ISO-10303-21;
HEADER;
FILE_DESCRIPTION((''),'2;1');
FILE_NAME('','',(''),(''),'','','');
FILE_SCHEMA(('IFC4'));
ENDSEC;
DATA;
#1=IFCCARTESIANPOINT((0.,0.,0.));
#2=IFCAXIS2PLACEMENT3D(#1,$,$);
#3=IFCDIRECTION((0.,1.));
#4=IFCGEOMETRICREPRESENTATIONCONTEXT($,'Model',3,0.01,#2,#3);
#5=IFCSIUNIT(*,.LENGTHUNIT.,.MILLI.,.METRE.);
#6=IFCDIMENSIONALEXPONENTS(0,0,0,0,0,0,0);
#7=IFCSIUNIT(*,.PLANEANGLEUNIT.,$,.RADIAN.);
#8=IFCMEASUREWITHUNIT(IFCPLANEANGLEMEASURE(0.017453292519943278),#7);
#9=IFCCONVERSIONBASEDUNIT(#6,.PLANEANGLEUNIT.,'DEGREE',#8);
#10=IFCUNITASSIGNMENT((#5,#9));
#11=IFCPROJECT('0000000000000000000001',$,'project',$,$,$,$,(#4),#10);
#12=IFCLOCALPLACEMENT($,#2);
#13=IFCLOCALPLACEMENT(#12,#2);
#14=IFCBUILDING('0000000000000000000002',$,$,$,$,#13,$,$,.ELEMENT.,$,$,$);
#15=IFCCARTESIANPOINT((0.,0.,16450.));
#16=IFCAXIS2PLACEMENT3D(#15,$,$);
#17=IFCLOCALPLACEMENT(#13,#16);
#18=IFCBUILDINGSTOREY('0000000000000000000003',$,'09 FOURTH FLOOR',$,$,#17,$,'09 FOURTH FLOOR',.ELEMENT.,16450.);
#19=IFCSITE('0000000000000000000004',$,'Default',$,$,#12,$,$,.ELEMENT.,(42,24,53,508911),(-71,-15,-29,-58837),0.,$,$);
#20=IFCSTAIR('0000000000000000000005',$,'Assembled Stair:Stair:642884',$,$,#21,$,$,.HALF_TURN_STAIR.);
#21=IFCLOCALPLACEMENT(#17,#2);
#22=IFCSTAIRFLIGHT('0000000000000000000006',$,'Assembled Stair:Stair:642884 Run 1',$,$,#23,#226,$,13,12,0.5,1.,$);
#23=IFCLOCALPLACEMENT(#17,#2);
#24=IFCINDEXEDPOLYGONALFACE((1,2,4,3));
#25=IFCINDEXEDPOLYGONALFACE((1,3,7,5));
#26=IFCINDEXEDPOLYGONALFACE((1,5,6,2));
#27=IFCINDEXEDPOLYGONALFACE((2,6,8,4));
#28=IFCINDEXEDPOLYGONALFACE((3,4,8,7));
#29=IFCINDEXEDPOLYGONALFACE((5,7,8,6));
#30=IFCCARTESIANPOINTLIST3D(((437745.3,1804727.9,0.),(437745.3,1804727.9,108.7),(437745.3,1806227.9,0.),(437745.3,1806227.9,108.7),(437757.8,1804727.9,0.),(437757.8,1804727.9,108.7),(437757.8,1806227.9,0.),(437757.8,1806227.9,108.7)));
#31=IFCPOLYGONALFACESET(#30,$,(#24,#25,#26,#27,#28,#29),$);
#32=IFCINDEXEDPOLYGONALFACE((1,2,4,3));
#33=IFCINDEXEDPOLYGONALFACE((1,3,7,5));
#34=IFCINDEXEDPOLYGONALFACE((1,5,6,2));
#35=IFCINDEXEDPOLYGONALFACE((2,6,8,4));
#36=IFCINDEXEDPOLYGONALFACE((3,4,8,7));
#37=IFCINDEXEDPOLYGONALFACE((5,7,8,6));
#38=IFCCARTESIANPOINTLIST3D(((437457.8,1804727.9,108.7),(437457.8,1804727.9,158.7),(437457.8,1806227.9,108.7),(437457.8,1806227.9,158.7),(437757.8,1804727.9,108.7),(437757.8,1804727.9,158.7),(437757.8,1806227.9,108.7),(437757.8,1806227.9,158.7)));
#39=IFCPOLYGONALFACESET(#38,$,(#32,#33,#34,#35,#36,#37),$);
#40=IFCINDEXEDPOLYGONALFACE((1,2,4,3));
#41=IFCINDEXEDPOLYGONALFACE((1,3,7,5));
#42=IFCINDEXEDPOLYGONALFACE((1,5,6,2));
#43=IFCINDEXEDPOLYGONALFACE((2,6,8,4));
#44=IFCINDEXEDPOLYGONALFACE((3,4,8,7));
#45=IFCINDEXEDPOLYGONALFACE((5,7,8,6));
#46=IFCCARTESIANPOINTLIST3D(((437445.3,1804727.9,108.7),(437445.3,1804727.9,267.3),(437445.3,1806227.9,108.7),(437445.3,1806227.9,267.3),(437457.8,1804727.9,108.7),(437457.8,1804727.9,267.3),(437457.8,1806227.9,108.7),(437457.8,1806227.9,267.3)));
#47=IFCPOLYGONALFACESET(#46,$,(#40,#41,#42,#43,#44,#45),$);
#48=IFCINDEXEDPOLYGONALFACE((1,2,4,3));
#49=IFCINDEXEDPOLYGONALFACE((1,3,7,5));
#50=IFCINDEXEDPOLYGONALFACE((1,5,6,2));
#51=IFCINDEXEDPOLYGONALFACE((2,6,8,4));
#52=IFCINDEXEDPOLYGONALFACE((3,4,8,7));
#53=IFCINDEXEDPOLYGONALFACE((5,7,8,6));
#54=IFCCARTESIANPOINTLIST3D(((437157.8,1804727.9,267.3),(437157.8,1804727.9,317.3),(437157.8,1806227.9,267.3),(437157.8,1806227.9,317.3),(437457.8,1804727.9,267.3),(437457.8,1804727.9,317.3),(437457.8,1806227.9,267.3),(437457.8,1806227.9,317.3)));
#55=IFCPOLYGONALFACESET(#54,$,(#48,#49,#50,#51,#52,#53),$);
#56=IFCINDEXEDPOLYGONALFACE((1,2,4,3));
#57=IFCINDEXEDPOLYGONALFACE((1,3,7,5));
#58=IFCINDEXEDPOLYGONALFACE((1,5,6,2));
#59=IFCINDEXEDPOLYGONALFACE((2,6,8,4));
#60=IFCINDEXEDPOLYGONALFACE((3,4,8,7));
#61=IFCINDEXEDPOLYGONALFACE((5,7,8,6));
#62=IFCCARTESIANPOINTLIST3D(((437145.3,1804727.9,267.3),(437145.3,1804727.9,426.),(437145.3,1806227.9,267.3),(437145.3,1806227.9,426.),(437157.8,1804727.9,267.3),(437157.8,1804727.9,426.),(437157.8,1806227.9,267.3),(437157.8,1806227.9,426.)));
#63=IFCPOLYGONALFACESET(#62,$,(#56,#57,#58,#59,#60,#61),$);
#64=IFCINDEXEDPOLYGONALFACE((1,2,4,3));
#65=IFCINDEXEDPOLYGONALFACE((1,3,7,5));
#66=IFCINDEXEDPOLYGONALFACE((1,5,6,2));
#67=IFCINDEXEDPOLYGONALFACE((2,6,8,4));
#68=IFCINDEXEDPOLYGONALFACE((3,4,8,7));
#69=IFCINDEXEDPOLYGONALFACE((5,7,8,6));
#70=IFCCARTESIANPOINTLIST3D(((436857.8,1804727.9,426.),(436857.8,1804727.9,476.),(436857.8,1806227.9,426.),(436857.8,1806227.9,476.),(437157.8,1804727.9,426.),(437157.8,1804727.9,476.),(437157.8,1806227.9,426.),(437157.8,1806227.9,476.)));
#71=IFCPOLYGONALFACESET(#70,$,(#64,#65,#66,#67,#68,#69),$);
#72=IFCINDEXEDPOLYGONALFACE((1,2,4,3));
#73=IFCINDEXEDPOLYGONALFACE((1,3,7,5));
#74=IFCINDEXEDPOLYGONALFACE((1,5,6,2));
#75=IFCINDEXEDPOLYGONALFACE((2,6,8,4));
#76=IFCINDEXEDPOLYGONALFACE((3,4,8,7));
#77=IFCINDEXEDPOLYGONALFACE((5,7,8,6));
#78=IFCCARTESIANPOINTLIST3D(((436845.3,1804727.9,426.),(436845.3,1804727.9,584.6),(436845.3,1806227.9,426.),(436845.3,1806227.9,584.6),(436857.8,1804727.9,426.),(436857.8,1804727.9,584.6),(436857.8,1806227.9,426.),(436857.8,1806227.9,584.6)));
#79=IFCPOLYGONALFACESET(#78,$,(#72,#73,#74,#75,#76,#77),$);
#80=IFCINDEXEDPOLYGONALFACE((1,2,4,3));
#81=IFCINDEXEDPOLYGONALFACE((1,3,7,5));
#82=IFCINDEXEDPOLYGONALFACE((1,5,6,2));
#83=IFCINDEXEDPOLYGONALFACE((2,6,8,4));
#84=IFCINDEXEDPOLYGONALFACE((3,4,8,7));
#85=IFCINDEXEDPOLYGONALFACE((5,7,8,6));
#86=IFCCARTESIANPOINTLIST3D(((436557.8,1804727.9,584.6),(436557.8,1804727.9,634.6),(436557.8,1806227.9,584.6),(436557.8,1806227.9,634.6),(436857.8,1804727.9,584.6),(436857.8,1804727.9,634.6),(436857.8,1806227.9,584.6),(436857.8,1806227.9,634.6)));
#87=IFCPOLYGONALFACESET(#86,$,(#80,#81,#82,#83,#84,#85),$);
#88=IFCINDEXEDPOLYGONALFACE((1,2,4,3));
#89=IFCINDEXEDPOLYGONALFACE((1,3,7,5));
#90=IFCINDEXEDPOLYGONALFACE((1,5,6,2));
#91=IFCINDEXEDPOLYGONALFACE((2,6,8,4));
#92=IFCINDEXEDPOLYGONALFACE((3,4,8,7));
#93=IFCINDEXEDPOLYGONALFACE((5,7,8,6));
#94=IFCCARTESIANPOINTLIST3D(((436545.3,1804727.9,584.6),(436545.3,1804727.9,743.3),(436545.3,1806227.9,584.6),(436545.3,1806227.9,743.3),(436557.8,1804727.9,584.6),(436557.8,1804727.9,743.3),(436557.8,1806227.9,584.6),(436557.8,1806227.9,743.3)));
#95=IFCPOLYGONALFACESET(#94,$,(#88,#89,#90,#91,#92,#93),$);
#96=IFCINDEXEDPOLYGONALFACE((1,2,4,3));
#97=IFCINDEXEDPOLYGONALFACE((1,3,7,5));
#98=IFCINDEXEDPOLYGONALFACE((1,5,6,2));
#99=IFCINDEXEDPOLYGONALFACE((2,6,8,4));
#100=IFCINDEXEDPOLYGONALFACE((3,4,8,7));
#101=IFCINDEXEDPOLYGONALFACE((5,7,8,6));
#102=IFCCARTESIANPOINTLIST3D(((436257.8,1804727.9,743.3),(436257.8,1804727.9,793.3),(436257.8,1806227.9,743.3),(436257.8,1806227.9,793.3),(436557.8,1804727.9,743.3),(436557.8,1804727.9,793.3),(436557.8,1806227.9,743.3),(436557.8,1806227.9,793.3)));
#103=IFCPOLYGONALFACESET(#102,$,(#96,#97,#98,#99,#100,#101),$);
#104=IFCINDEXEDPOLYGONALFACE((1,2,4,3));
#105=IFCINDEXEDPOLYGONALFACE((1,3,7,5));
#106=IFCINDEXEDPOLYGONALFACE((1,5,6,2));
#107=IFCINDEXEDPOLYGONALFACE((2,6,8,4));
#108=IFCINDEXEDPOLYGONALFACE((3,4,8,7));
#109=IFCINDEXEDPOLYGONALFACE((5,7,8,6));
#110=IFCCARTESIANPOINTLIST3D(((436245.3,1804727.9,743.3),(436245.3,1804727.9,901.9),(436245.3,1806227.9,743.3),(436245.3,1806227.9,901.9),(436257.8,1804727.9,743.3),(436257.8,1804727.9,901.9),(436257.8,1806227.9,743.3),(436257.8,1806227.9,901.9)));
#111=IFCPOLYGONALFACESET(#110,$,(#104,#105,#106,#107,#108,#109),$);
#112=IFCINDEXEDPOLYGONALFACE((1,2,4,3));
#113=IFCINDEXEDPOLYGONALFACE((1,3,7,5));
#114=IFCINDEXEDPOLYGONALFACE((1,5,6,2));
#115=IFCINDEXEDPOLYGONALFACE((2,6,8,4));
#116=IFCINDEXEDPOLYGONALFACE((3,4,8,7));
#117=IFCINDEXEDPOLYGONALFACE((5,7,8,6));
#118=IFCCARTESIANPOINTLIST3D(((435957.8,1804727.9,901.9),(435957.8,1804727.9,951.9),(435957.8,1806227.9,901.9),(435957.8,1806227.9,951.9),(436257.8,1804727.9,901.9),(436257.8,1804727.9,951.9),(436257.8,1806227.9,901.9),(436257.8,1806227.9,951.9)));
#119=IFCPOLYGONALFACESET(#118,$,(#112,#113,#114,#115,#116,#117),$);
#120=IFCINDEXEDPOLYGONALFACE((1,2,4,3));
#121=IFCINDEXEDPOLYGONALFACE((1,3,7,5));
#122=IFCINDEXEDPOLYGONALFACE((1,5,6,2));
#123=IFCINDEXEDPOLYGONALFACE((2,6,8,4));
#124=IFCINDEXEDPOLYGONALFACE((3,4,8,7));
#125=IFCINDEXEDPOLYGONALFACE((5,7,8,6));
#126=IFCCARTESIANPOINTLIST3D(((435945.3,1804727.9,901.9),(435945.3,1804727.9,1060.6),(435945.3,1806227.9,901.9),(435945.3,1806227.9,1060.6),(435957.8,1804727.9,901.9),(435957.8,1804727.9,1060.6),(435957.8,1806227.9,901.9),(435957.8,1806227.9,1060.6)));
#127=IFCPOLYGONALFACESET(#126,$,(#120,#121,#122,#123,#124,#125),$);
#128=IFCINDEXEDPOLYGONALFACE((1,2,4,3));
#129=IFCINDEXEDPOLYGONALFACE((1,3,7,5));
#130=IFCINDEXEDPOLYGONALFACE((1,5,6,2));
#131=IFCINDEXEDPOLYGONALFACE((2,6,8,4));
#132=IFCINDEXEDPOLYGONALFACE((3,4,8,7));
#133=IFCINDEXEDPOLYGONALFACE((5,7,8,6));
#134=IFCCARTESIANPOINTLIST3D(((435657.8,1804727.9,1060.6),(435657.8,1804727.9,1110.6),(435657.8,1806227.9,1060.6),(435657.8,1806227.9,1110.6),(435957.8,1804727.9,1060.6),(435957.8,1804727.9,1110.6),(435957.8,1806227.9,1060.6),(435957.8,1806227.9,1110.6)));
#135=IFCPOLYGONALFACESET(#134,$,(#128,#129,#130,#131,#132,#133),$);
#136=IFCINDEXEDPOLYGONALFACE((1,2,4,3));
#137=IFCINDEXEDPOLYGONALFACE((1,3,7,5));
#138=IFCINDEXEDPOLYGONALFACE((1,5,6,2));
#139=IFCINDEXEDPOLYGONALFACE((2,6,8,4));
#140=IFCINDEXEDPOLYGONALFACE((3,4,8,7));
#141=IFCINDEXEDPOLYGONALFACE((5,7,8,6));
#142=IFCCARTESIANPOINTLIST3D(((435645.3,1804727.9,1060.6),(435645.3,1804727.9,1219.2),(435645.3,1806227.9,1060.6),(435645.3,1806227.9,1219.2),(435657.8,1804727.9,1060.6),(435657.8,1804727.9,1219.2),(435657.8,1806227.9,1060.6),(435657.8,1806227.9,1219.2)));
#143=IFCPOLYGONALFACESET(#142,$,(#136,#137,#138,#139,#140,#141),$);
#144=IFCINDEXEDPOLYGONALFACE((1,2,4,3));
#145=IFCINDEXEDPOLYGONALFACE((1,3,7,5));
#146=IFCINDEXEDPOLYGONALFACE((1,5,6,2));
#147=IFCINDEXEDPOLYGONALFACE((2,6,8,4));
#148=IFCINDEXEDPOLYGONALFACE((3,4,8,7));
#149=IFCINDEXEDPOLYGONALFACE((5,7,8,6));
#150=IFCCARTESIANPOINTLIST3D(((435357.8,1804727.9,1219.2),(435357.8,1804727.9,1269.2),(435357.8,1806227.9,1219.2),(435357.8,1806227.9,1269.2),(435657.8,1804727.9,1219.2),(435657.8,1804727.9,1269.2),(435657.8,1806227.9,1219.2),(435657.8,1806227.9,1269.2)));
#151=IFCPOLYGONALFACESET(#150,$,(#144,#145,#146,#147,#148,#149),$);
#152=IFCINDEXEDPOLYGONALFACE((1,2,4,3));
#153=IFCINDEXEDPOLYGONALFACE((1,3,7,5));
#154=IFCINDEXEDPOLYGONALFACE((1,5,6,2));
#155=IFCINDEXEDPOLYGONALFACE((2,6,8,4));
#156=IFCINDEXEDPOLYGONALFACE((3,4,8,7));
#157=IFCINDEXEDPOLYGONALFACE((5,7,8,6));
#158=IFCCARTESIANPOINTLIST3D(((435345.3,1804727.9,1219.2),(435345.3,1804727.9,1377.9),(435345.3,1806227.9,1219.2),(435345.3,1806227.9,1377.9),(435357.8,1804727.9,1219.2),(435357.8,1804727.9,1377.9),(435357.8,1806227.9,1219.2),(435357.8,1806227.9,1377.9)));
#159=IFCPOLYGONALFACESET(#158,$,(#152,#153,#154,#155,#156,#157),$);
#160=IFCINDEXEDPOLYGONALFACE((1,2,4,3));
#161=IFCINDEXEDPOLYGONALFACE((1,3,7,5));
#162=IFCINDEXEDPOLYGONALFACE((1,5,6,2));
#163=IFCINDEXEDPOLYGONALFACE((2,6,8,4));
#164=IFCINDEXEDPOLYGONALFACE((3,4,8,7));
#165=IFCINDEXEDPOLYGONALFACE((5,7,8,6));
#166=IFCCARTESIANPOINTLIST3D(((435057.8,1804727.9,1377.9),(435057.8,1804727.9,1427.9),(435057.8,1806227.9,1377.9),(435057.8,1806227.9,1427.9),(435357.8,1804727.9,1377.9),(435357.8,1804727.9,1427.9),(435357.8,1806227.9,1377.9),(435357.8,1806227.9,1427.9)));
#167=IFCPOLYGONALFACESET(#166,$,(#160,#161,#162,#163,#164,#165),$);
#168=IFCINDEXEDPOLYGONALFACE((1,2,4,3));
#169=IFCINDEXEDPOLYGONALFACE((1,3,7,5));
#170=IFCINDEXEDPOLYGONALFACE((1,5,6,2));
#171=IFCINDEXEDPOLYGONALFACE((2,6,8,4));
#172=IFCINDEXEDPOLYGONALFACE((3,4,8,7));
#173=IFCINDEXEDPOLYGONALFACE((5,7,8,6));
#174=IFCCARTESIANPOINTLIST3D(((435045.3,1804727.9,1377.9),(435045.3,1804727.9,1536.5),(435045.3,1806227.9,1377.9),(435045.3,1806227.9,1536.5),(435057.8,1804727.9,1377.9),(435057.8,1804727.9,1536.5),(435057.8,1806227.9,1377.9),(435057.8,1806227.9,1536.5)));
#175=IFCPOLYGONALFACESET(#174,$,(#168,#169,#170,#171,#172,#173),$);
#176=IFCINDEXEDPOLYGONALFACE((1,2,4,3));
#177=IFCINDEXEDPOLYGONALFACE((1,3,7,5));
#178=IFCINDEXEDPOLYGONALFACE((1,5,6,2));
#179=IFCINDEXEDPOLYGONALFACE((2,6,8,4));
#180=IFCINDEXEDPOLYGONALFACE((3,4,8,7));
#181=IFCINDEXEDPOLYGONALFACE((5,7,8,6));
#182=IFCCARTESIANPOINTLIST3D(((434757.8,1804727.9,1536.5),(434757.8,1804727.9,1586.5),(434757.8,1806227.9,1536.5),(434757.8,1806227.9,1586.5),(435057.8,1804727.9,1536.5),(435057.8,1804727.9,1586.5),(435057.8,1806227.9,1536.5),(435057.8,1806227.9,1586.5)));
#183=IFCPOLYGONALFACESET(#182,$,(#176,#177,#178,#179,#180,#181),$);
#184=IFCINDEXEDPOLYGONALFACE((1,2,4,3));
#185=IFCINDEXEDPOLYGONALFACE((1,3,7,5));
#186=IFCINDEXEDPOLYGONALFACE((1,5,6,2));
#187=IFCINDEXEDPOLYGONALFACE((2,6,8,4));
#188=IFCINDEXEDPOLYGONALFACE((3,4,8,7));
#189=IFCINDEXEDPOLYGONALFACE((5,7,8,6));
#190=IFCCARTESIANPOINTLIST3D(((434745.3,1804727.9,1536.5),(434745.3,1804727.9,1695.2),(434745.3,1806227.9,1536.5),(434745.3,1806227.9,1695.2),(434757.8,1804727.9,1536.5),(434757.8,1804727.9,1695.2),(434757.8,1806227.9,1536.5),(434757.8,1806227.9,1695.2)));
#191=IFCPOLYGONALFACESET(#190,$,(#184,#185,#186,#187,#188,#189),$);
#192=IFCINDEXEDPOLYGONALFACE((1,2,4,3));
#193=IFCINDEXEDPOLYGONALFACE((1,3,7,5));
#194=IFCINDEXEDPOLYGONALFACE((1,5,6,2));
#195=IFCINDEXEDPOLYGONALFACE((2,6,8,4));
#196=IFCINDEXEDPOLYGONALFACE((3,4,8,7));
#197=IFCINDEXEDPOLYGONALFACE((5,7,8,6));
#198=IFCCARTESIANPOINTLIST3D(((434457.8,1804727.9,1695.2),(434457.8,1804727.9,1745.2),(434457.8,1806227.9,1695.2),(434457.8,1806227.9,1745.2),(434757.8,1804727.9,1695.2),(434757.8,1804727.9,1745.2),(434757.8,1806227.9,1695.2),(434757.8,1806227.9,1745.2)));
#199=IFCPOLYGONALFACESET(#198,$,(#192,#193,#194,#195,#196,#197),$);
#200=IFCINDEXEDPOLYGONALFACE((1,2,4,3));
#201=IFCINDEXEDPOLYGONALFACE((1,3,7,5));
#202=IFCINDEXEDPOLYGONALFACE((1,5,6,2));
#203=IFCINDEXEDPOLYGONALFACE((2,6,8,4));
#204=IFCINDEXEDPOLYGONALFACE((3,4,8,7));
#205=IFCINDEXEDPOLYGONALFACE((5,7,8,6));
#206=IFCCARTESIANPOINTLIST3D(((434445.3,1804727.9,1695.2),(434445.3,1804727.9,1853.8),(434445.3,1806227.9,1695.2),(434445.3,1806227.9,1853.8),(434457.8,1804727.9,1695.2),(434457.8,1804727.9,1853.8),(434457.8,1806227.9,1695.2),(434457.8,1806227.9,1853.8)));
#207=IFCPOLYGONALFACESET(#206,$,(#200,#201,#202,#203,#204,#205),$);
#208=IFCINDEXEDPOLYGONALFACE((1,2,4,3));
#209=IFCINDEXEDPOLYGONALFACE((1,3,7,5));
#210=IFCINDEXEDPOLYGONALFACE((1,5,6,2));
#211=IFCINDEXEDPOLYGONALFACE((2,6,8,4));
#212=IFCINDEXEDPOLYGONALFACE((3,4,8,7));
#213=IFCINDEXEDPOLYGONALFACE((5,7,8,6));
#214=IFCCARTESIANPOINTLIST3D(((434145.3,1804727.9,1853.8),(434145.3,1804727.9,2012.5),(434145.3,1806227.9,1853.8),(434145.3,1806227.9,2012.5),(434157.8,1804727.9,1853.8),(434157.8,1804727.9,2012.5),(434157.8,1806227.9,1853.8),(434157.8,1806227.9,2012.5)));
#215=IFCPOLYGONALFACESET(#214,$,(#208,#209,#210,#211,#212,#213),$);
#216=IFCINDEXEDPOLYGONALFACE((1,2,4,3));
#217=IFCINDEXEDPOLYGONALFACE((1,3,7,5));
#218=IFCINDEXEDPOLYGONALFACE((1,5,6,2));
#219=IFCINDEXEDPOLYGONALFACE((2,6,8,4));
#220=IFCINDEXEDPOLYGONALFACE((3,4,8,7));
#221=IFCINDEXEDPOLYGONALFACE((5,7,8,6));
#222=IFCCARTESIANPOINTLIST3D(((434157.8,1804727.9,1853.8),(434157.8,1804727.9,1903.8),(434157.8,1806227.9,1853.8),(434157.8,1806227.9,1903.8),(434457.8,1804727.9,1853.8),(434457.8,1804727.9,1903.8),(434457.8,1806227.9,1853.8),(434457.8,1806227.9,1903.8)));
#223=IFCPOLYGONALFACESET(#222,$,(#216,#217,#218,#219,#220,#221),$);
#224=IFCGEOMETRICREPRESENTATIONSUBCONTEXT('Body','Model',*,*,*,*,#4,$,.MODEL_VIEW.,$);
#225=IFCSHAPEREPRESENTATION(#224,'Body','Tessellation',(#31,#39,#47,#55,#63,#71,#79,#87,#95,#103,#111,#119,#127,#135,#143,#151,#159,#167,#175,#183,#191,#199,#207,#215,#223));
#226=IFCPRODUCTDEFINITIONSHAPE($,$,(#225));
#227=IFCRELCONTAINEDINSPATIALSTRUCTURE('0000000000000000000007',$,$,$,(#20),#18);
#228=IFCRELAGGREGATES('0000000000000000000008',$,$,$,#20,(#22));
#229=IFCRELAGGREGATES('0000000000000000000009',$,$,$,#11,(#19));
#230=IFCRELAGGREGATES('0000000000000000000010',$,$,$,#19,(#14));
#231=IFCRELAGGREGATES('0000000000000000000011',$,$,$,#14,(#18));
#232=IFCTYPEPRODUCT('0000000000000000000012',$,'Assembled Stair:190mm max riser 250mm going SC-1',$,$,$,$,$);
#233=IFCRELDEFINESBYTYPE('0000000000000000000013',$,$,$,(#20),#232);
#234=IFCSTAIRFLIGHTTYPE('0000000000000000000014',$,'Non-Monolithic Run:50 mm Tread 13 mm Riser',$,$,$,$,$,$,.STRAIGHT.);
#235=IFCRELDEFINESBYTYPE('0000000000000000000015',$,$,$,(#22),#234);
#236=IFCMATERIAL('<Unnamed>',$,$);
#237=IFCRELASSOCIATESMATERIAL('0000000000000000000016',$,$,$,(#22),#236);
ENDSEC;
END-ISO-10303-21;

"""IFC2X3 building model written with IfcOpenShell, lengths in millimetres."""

from ifc_helpers import new_model, entity, si_unit, converted_unit, direction, frame, origin, origin_2d_with_axis, place, context, subcontext, project, spatial, rectangle, extrude, material, type_object, element, aggregate, save


model = new_model("IFC2X3")

# Units and contexts
model_context = context("Model", 3, precision=0.01, world=origin(), true_north=direction((0.0, 1.0)))
body_context = subcontext(model_context, "Body", "Model", "MODEL_VIEW")
ifc_project = project(units=[si_unit("LENGTHUNIT", "METRE", prefix="MILLI"), converted_unit("PLANEANGLEUNIT", "DEGREE", entity("IfcPlaneAngleMeasure", 0.017453292519943278), si_unit("PLANEANGLEUNIT", "RADIAN"), dimensions=[0, 0, 0, 0, 0, 0, 0])], contexts=[model_context])

# Site, building, storey
site_placement = place(None, origin())
site = spatial("IfcSite", under=ifc_project, at=site_placement, Name="Default", CompositionType="ELEMENT", RefLatitude=(42, 24, 53, 508911), RefLongitude=(-71, -15, -29, -58837), RefElevation=0.0)
building_placement = place(site_placement, origin())
building = spatial("IfcBuilding", under=site, at=building_placement, CompositionType="ELEMENT")
storey_placement = place(building_placement, frame((0.0, 0.0, 16450.0)))
storey = spatial("IfcBuildingStorey", under=building, at=storey_placement, Name="09 FOURTH FLOOR", LongName="09 FOURTH FLOOR", CompositionType="ELEMENT", Elevation=16450.0)

# Stair
type_product_1 = type_object("IfcTypeProduct", Name="Assembled Stair:190mm max riser 250mm going SC-1")
stair_1_placement = place(storey_placement, origin())
stair_1 = element("IfcStair", 1, at=stair_1_placement, inside=storey, type_object=type_product_1, Name="Assembled Stair:Stair:642884", ShapeType="HALF_TURN_STAIR")
ifc_material_1 = material(Name="<Unnamed>")

# Stair flight
stair_flight_type = type_object("IfcStairFlightType", Name="Non-Monolithic Run:50 mm Tread 13 mm Riser", PredefinedType="STRAIGHT")
stair_flight_1_placement = place(stair_1_placement, origin())
stair_flight_1 = element("IfcStairFlight", 2, at=stair_flight_1_placement, type_object=stair_flight_type, material=ifc_material_1, Name="Assembled Stair:Stair:642884 Run 1", NumberOfRiser=13, NumberOfTreads=12, RiserHeight=0.5, TreadLength=1.0, context=body_context, shape_type="SweptSolid", body=[
    extrude(rectangle(XDim=1500.0, YDim=12.5, at=origin_2d_with_axis()), frame((437751.5, 1805477.9, 0.0), z_axis=(0.0, 0.0, 1.0), x_axis=(0.0, -1.0, 0.0)), (0.0, 0.0, 1.0), 108.7),
    extrude(rectangle(XDim=300.0, YDim=1500.0, at=origin_2d_with_axis()), frame((437607.8, 1805477.9, 108.7)), (0.0, 0.0, 1.0), 50.0),
    extrude(rectangle(XDim=1500.0, YDim=12.5, at=origin_2d_with_axis()), frame((437451.5, 1805477.9, 108.7), z_axis=(0.0, 0.0, 1.0), x_axis=(0.0, -1.0, 0.0)), (0.0, 0.0, 1.0), 158.7),
    extrude(rectangle(XDim=300.0, YDim=1500.0, at=origin_2d_with_axis()), frame((437307.8, 1805477.9, 267.3)), (0.0, 0.0, 1.0), 50.0),
    extrude(rectangle(XDim=1500.0, YDim=12.5, at=origin_2d_with_axis()), frame((437151.5, 1805477.9, 267.3), z_axis=(0.0, 0.0, 1.0), x_axis=(0.0, -1.0, 0.0)), (0.0, 0.0, 1.0), 158.7),
    extrude(rectangle(XDim=300.0, YDim=1500.0, at=origin_2d_with_axis()), frame((437007.8, 1805477.9, 426.0)), (0.0, 0.0, 1.0), 50.0),
    extrude(rectangle(XDim=1500.0, YDim=12.5, at=origin_2d_with_axis()), frame((436851.5, 1805477.9, 426.0), z_axis=(0.0, 0.0, 1.0), x_axis=(0.0, -1.0, 0.0)), (0.0, 0.0, 1.0), 158.7),
    extrude(rectangle(XDim=300.0, YDim=1500.0, at=origin_2d_with_axis()), frame((436707.8, 1805477.9, 584.6)), (0.0, 0.0, 1.0), 50.0),
    extrude(rectangle(XDim=1500.0, YDim=12.5, at=origin_2d_with_axis()), frame((436551.5, 1805477.9, 584.6), z_axis=(0.0, 0.0, 1.0), x_axis=(0.0, -1.0, 0.0)), (0.0, 0.0, 1.0), 158.7),
    extrude(rectangle(XDim=300.0, YDim=1500.0, at=origin_2d_with_axis()), frame((436407.8, 1805477.9, 743.3)), (0.0, 0.0, 1.0), 50.0),
    extrude(rectangle(XDim=1500.0, YDim=12.5, at=origin_2d_with_axis()), frame((436251.5, 1805477.9, 743.3), z_axis=(0.0, 0.0, 1.0), x_axis=(0.0, -1.0, 0.0)), (0.0, 0.0, 1.0), 158.7),
    extrude(rectangle(XDim=300.0, YDim=1500.0, at=origin_2d_with_axis()), frame((436107.8, 1805477.9, 901.9)), (0.0, 0.0, 1.0), 50.0),
    extrude(rectangle(XDim=1500.0, YDim=12.5, at=origin_2d_with_axis()), frame((435951.5, 1805477.9, 901.9), z_axis=(0.0, 0.0, 1.0), x_axis=(0.0, -1.0, 0.0)), (0.0, 0.0, 1.0), 158.7),
    extrude(rectangle(XDim=300.0, YDim=1500.0, at=origin_2d_with_axis()), frame((435807.8, 1805477.9, 1060.6)), (0.0, 0.0, 1.0), 50.0),
    extrude(rectangle(XDim=1500.0, YDim=12.5, at=origin_2d_with_axis()), frame((435651.5, 1805477.9, 1060.6), z_axis=(0.0, 0.0, 1.0), x_axis=(0.0, -1.0, 0.0)), (0.0, 0.0, 1.0), 158.7),
    extrude(rectangle(XDim=300.0, YDim=1500.0, at=origin_2d_with_axis()), frame((435507.8, 1805477.9, 1219.2)), (0.0, 0.0, 1.0), 50.0),
    extrude(rectangle(XDim=1500.0, YDim=12.5, at=origin_2d_with_axis()), frame((435351.5, 1805477.9, 1219.2), z_axis=(0.0, 0.0, 1.0), x_axis=(0.0, -1.0, 0.0)), (0.0, 0.0, 1.0), 158.7),
    extrude(rectangle(XDim=300.0, YDim=1500.0, at=origin_2d_with_axis()), frame((435207.8, 1805477.9, 1377.9)), (0.0, 0.0, 1.0), 50.0),
    extrude(rectangle(XDim=1500.0, YDim=12.5, at=origin_2d_with_axis()), frame((435051.5, 1805477.9, 1377.9), z_axis=(0.0, 0.0, 1.0), x_axis=(0.0, -1.0, 0.0)), (0.0, 0.0, 1.0), 158.7),
    extrude(rectangle(XDim=300.0, YDim=1500.0, at=origin_2d_with_axis()), frame((434907.8, 1805477.9, 1536.5)), (0.0, 0.0, 1.0), 50.0),
    extrude(rectangle(XDim=1500.0, YDim=12.5, at=origin_2d_with_axis()), frame((434751.5, 1805477.9, 1536.5), z_axis=(0.0, 0.0, 1.0), x_axis=(0.0, -1.0, 0.0)), (0.0, 0.0, 1.0), 158.7),
    extrude(rectangle(XDim=300.0, YDim=1500.0, at=origin_2d_with_axis()), frame((434607.8, 1805477.9, 1695.2)), (0.0, 0.0, 1.0), 50.0),
    extrude(rectangle(XDim=1500.0, YDim=12.5, at=origin_2d_with_axis()), frame((434451.5, 1805477.9, 1695.2), z_axis=(0.0, 0.0, 1.0), x_axis=(0.0, -1.0, 0.0)), (0.0, 0.0, 1.0), 158.7),
    extrude(rectangle(XDim=1500.0, YDim=12.5, at=origin_2d_with_axis()), frame((434151.5, 1805477.9, 1853.8), z_axis=(0.0, 0.0, 1.0), x_axis=(0.0, -1.0, 0.0)), (0.0, 0.0, 1.0), 158.7),
    extrude(rectangle(XDim=300.0, YDim=1500.0, at=origin_2d_with_axis()), frame((434307.8, 1805477.9, 1853.8)), (0.0, 0.0, 1.0), 50.0),
])
aggregate(stair_1, [stair_flight_1])

save(model, "model.ifc")
